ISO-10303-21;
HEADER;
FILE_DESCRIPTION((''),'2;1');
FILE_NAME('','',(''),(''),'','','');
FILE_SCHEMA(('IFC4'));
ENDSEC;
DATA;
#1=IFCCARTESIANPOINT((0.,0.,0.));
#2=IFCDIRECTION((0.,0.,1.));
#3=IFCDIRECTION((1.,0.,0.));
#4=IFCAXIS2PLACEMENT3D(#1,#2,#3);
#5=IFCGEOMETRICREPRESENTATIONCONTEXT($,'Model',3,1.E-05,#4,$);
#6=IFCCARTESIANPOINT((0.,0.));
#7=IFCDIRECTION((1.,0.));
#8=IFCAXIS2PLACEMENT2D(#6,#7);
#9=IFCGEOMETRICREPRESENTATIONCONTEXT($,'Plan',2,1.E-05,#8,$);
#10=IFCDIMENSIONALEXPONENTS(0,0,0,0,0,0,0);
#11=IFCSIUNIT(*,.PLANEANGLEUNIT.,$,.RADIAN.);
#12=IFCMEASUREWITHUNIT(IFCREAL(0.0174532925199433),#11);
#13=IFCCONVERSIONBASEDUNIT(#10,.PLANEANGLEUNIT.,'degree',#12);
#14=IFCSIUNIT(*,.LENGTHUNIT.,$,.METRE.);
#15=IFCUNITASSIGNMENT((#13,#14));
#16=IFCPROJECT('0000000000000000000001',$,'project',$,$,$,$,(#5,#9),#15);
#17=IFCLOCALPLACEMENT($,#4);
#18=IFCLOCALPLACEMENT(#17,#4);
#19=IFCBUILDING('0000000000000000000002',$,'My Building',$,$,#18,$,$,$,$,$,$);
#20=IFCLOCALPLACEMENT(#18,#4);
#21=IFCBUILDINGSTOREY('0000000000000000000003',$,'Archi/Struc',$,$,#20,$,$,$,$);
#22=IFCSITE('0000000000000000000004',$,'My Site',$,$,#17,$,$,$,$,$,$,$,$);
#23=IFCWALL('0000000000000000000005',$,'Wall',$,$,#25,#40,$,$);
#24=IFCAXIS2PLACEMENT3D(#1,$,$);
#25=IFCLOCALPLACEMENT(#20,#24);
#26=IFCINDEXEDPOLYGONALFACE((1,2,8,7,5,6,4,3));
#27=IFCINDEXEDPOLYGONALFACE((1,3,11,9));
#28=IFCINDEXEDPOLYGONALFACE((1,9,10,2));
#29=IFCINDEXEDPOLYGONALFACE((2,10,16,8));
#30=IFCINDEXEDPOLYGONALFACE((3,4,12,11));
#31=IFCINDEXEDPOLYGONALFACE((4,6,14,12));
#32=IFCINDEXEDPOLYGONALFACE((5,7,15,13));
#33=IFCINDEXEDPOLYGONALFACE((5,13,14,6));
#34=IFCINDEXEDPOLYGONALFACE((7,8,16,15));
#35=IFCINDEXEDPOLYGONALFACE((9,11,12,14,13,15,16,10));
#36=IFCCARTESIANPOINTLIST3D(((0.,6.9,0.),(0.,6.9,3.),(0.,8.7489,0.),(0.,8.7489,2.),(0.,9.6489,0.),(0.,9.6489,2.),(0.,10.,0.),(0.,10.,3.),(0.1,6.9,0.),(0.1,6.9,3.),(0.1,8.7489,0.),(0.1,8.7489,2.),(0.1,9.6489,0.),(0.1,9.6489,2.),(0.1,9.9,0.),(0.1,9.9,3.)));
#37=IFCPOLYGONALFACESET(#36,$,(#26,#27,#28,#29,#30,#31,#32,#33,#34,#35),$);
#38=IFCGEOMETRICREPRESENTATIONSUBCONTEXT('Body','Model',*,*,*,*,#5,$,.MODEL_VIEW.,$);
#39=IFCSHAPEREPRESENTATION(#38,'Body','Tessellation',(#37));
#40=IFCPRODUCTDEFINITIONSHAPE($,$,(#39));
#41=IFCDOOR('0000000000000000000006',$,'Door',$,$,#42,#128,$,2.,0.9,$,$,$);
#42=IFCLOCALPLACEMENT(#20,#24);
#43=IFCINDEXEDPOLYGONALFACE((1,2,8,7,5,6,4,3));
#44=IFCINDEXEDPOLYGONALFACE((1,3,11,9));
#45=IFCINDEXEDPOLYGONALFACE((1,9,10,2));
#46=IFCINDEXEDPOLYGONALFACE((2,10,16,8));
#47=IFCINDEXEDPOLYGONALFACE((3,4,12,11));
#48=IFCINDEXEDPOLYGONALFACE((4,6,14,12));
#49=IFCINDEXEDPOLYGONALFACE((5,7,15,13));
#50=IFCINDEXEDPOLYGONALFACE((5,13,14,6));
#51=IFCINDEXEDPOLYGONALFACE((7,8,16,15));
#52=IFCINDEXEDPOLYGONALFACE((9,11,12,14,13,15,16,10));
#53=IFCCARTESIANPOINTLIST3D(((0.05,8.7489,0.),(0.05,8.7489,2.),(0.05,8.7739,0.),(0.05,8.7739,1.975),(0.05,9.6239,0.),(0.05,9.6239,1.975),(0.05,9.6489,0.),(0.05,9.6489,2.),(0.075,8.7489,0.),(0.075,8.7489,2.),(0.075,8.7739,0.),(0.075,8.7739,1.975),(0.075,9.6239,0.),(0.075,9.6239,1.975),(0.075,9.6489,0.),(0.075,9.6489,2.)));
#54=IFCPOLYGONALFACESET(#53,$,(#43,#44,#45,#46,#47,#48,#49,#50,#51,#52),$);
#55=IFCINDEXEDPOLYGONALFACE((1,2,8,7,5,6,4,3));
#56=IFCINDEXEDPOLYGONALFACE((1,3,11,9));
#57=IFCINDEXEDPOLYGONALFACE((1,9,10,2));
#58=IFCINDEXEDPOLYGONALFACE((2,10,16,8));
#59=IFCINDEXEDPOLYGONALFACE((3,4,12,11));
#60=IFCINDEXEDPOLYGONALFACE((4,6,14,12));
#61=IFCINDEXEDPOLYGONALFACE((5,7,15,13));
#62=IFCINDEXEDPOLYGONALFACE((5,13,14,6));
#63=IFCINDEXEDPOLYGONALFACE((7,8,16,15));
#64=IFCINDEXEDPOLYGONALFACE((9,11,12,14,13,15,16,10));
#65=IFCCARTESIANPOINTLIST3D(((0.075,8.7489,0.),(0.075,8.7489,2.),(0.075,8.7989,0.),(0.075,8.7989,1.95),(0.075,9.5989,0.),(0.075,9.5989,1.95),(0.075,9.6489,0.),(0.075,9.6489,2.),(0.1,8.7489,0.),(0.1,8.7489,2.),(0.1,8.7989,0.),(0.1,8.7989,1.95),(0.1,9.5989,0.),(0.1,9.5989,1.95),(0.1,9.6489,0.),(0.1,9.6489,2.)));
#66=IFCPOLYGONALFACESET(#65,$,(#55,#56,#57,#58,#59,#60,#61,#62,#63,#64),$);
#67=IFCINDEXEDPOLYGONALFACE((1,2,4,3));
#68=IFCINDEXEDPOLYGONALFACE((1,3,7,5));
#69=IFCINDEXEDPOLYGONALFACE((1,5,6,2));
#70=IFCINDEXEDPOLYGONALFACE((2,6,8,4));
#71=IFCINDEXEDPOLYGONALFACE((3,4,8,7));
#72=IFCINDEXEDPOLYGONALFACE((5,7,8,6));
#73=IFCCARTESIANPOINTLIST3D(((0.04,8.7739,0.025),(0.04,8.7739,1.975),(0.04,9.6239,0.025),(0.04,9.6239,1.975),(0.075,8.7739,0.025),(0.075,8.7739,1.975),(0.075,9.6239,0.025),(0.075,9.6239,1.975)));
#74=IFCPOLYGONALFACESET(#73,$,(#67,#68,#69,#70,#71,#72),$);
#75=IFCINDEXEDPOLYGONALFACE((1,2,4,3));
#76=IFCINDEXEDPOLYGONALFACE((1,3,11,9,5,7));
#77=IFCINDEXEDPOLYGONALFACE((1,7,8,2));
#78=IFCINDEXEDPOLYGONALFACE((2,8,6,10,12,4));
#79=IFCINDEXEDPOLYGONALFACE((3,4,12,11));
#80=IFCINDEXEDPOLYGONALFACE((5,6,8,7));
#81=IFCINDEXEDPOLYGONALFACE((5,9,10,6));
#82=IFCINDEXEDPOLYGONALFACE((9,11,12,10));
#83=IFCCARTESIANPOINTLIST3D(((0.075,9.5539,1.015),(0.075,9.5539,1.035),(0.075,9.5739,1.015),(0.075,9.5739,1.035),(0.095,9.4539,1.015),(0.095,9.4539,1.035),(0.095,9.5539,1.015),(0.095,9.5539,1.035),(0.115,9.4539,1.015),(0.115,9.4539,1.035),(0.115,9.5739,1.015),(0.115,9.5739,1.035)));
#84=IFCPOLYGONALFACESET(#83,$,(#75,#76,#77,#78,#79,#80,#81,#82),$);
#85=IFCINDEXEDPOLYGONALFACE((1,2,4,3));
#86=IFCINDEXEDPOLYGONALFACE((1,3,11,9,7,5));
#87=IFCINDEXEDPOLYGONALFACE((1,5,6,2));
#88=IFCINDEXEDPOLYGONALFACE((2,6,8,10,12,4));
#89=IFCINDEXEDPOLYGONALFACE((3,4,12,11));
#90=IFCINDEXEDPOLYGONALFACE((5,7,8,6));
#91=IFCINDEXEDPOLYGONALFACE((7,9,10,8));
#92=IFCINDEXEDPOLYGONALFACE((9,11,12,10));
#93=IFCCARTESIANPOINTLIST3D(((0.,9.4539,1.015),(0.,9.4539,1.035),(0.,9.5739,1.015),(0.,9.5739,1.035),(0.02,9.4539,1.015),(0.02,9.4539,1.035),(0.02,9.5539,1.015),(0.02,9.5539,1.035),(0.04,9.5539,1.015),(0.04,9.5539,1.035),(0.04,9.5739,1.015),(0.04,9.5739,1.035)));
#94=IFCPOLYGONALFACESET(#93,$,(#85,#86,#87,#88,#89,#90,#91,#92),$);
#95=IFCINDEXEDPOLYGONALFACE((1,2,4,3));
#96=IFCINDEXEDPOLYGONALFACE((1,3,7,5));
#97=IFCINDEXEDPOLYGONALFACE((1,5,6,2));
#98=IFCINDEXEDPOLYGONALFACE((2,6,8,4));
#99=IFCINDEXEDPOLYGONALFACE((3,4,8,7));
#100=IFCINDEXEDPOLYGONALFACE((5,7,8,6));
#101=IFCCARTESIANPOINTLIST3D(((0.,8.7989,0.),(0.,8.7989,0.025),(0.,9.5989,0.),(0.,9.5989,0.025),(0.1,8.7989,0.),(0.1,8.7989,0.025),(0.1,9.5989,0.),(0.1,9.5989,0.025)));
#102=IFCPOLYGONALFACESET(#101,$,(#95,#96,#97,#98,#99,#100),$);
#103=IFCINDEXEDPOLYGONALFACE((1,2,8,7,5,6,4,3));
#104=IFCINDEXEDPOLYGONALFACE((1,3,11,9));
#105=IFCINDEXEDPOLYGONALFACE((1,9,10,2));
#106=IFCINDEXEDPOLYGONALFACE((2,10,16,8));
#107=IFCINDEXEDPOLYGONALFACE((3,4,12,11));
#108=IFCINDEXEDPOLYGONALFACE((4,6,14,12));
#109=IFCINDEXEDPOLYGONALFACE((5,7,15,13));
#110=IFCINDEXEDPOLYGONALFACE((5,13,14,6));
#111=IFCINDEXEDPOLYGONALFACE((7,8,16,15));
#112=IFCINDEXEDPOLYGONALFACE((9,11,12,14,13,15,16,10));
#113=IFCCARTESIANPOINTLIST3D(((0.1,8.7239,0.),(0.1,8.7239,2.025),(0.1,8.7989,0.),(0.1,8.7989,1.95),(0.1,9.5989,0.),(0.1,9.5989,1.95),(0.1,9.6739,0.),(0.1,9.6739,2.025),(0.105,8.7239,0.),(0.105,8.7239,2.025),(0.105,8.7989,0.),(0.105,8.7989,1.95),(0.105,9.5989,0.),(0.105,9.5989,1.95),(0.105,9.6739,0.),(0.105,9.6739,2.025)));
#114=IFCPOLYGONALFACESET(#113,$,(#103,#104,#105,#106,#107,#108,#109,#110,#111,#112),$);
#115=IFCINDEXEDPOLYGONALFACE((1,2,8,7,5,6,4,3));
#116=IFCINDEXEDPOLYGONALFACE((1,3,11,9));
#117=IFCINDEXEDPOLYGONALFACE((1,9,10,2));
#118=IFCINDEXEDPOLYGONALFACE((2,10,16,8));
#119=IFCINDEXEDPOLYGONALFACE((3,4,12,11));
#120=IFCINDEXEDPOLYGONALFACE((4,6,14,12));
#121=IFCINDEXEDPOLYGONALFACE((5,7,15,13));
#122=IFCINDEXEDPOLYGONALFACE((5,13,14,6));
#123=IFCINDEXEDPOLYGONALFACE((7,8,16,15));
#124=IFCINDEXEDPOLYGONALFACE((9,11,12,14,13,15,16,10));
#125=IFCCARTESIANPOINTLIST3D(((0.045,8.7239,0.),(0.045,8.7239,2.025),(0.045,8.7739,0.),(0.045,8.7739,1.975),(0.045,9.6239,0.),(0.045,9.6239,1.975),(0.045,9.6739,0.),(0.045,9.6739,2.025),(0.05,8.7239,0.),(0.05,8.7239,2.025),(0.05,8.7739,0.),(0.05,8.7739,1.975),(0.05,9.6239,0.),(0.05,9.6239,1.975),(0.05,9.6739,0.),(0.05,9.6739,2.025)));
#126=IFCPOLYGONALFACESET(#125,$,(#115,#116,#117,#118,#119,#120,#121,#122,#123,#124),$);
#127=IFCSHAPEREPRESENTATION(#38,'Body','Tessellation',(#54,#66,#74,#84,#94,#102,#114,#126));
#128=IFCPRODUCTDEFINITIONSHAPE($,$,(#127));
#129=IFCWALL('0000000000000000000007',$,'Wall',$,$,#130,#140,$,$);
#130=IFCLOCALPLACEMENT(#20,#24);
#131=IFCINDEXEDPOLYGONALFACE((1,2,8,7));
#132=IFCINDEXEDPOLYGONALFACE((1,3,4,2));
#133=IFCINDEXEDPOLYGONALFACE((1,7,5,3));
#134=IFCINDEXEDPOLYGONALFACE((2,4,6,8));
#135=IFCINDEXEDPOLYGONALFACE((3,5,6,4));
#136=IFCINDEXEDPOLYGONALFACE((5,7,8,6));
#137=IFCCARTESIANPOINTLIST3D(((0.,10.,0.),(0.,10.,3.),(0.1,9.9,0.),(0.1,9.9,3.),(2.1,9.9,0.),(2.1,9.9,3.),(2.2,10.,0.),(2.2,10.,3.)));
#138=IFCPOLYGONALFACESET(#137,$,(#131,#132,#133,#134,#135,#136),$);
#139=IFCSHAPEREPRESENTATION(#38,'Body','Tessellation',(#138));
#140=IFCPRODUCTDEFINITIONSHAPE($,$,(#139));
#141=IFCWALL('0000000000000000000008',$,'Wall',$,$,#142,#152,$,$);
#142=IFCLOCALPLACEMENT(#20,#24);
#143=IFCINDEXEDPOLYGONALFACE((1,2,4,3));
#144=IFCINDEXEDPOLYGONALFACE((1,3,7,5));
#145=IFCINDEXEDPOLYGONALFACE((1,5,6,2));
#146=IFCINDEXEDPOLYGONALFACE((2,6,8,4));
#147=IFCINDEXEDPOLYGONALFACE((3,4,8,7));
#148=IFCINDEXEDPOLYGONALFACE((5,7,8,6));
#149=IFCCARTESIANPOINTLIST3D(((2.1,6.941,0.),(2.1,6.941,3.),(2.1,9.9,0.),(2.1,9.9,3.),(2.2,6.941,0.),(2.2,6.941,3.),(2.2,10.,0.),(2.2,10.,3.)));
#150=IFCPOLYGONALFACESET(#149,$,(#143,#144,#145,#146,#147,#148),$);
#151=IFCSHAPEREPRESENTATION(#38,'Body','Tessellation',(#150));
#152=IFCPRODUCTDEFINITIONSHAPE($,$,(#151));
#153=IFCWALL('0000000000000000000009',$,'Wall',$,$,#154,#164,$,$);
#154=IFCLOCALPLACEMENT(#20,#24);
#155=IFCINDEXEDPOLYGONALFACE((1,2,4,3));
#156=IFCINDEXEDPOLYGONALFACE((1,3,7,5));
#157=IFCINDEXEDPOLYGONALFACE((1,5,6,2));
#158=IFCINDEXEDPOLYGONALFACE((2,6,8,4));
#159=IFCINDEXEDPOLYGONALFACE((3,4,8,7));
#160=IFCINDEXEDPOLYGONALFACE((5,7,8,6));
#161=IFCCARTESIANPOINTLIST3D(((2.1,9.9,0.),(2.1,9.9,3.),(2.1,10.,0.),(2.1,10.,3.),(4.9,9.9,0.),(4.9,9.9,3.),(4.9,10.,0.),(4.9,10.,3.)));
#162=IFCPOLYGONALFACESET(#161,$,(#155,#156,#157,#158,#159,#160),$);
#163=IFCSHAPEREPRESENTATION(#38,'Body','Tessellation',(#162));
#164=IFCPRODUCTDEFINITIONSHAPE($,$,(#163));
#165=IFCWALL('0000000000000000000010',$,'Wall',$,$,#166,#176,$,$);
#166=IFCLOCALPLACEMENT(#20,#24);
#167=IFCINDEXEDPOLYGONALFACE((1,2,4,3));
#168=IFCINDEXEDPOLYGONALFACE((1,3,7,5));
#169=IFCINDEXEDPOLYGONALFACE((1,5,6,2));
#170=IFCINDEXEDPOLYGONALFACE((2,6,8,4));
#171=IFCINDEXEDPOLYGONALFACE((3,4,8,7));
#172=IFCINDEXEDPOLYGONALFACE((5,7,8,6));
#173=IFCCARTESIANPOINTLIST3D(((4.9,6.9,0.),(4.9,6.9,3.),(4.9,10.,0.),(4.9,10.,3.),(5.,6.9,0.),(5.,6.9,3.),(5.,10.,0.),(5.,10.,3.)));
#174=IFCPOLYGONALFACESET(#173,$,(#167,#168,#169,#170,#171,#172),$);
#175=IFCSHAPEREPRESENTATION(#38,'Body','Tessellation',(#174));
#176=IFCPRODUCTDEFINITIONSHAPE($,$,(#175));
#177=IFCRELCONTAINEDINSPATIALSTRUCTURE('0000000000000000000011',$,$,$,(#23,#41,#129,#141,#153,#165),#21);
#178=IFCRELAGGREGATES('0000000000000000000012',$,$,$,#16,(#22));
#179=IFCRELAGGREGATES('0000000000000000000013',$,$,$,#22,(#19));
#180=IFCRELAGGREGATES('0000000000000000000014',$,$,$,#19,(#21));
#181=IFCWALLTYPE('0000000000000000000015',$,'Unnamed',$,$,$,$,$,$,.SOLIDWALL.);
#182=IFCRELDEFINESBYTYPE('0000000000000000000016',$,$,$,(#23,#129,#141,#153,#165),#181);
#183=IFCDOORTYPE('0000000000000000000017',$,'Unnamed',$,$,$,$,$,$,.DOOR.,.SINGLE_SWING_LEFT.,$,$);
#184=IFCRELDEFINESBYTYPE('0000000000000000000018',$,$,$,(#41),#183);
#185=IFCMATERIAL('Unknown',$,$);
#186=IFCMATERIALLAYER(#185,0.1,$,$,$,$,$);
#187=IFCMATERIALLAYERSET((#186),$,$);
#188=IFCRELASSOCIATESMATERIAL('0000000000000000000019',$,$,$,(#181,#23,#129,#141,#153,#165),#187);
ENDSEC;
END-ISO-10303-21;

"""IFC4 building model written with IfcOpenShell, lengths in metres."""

from ifc_helpers import new_model, entity, si_unit, converted_unit, frame, origin_with_axes, origin_2d_with_axis, place, context, subcontext, project, spatial, line, indexed_curve, outline, extrude, shape, source, transform, mapped, material, layer, layer_set, layer_usage, type_object, type_shapes, element, fill, save


model = new_model("IFC4")

# Units and contexts
model_context = context("Model", 3, precision=1e-05, world=origin_with_axes())
plan_context = context("Plan", 2, precision=1e-05, world=origin_2d_with_axis())
body_context_1 = subcontext(model_context, "Body", "Model", "MODEL_VIEW")
body_context_2 = subcontext(plan_context, "Body", "Plan", "PLAN_VIEW")
ifc_project = project(units=[converted_unit("PLANEANGLEUNIT", "degree", entity("IfcReal", 0.0174532925199433), si_unit("PLANEANGLEUNIT", "RADIAN"), dimensions=[0, 0, 0, 0, 0, 0, 0]), si_unit("LENGTHUNIT", "METRE")], contexts=[model_context, plan_context])

# Site, building, storey
site_placement = place(None, origin_with_axes())
site = spatial("IfcSite", under=ifc_project, at=site_placement, Name="My Site")
building_placement = place(site_placement, origin_with_axes())
building = spatial("IfcBuilding", under=site, at=building_placement, Name="My Building")
storey_placement = place(building_placement, origin_with_axes())
storey = spatial("IfcBuildingStorey", under=building, at=storey_placement, Name="Archi/Struc")

# Shared definitions
ifc_material = material(Name="Unknown")

# Shared definitions
ifc_layer_1 = layer(ifc_material, 0.1)
ifc_layer_set_1 = layer_set([ifc_layer_1])
wall_type = type_object("IfcWallType", Name="Unnamed", PredefinedType="SOLIDWALL", material=ifc_layer_set_1)

# Shared definitions
shared_shape_1 = source(origin_with_axes(), body_context_1, "Body", "SweptSolid", [
    extrude(outline(indexed_curve([(0.0, 0.0), (0.9, 0.0), (0.9, 2.0), (0.0, 2.0)], segments=[line(1, 2, 3, 4, 1)])), frame((0.0, -0.6, 0.0), z_axis=(0.0, -1.0, 0.0), x_axis=(1.0, 0.0, 0.0)), (0.0, 0.0, -1.0), 1.2),
])
door_type = type_object("IfcDoorType", Name="Unnamed", OperationType="SINGLE_SWING_LEFT", PredefinedType="DOOR")
shared_shape_2 = source(origin_with_axes(), body_context_1, "Body", "SweptSolid", [
    extrude(outline(indexed_curve([(0.0, 0.0), (0.0, 2.0), (0.9, 2.0), (0.9, 0.0), (0.875, 0.0), (0.875, 1.975), (0.025, 1.975), (0.025, 0.0)], segments=[line(1, 2, 3, 4, 5, 6, 7, 8, 1)])), frame((0.0, 0.025, 0.0), z_axis=(0.0, -1.0, 0.0), x_axis=(1.0, 0.0, 0.0)), (0.0, 0.0, -1.0), 0.025),
    extrude(outline(indexed_curve([(0.0, 0.0), (0.0, 2.0), (0.9, 2.0), (0.9, 0.0), (0.85, 0.0), (0.85, 1.95), (0.05, 1.95), (0.05, 0.0)], segments=[line(1, 2, 3, 4, 5, 6, 7, 8, 1)])), frame((0.0, 0.0, 0.0), z_axis=(0.0, -1.0, 0.0), x_axis=(1.0, 0.0, 0.0)), (0.0, 0.0, -1.0), 0.025),
    extrude(outline(indexed_curve([(0.0, 0.0), (0.85, 0.0), (0.85, 0.035), (0.0, 0.035)], segments=[line(1, 2, 3, 4, 1)])), frame((0.025, 0.025, 0.025), z_axis=(0.0, 0.0, 1.0), x_axis=(1.0, 0.0, 0.0)), (0.0, 0.0, 1.0), 1.95),
    extrude(outline(indexed_curve([(0.0, 0.0), (0.0, -0.04), (-0.12, -0.04), (-0.12, -0.02), (-0.02, -0.02), (-0.02, 0.0)], segments=[line(1, 2, 3, 4, 5, 6, 1)])), frame((0.825, 0.025, 1.015), z_axis=(0.0, 0.0, 1.0), x_axis=(1.0, 0.0, 0.0)), (0.0, 0.0, 1.0), 0.02),
    extrude(outline(indexed_curve([(0.0, 0.0), (0.0, 0.04), (-0.12, 0.04), (-0.12, 0.02), (-0.02, 0.02), (-0.02, 0.0)], segments=[line(1, 2, 3, 4, 5, 6, 1)])), frame((0.825, 0.06, 1.015), z_axis=(0.0, 0.0, 1.0), x_axis=(1.0, 0.0, 0.0)), (0.0, 0.0, 1.0), 0.02),
    extrude(outline(indexed_curve([(0.0, 0.0), (0.8, 0.0), (0.8, 0.1), (0.0, 0.1)], segments=[line(1, 2, 3, 4, 1)])), frame((0.05, 0.0, 0.0), z_axis=(0.0, 0.0, 1.0), x_axis=(1.0, 0.0, 0.0)), (0.0, 0.0, 1.0), 0.025),
    extrude(outline(indexed_curve([(0.0, 0.0), (0.0, 2.025), (0.95, 2.025), (0.95, 0.0), (0.875, 0.0), (0.875, 1.95), (0.075, 1.95), (0.075, 0.0)], segments=[line(1, 2, 3, 4, 5, 6, 7, 8, 1)])), frame((-0.025, -0.005, 0.0), z_axis=(0.0, -1.0, 0.0), x_axis=(1.0, 0.0, 0.0)), (0.0, 0.0, -1.0), 0.005),
    extrude(outline(indexed_curve([(0.0, 0.0), (0.0, 2.025), (0.95, 2.025), (0.95, 0.0), (0.9, 0.0), (0.9, 1.975), (0.05, 1.975), (0.05, 0.0)], segments=[line(1, 2, 3, 4, 5, 6, 7, 8, 1)])), frame((-0.025, 0.05, 0.0), z_axis=(0.0, -1.0, 0.0), x_axis=(1.0, 0.0, 0.0)), (0.0, 0.0, -1.0), 0.005),
])
shared_shape_3 = source(origin_with_axes(), body_context_2, "Body", "Curve2D", [
    entity("IfcIndexedPolyCurve", entity("IfcCartesianPointList2D", [[0.0, 0.0], [0.0, 0.05], [0.025, 0.05], [0.025, 0.025], [0.05, 0.025], [0.05, 0.0]]), [entity("IfcLineIndex", [1, 2, 3, 4, 5, 6, 1])]),
    entity("IfcIndexedPolyCurve", entity("IfcCartesianPointList2D", [[0.9, 0.0], [0.9, 0.05], [0.875, 0.05], [0.875, 0.025], [0.85, 0.025], [0.85, 0.0]]), [entity("IfcLineIndex", [1, 2, 3, 4, 5, 6, 1])]),
    entity("IfcTrimmedCurve", entity("IfcEllipse", entity("IfcAxis2Placement2D", entity("IfcCartesianPoint", [0.06, 0.05]), entity("IfcDirection", [1.0, 0.0])), 0.815, 0.85), [entity("IfcCartesianPoint", [0.875, 0.05])], [entity("IfcCartesianPoint", [0.06, 0.9])], True, "CARTESIAN"),
    entity("IfcIndexedPolyCurve", entity("IfcCartesianPointList2D", [[0.025, 0.05], [0.06, 0.05], [0.06, 0.9], [0.025, 0.9]]), [entity("IfcLineIndex", [1, 2, 3, 4, 1])]),
])
type_shapes(door_type, [shared_shape_2, shared_shape_3])

# Wall, opening, door
ifc_layer_usage_1 = layer_usage(ifc_layer_set_1, "AXIS2", "POSITIVE", 0.0)
wall_1_placement = place(storey_placement, frame((0.1, 6.9, 0.0), z_axis=(0.0, 0.0, 1.0), x_axis=(0.0, 1.0, 0.0)))
wall_1 = element("IfcWall", 1, at=wall_1_placement, inside=storey, type_object=wall_type, material=ifc_layer_usage_1, Name="Wall", context=body_context_1, shape_type="SweptSolid", body=[
    extrude(outline(indexed_curve([(0.0, 0.0), (0.0, 0.1), (3.1, 0.1), (3.0, 0.0)], segments=[line(1, 2, 3, 4, 1)])), origin_with_axes(), (0.0, 0.0, 1.0), 3.0),
])
opening_1_placement = place(wall_1_placement, frame((1.8489, 0.0, 0.0), z_axis=(0.0, 0.0, 1.0), x_axis=(1.0, 0.0, 0.0)))
opening_1 = element("IfcOpeningElement", 2, at=opening_1_placement, cuts=wall_1, PredefinedType="OPENING", context=body_context_1, shape_type="MappedRepresentation", body=[
    mapped(shared_shape_1, transform((0.0, 0.0, 0.0), x_axis=(1.0, 0.0, 0.0), y_axis=(0.0, 1.0, 0.0), z_axis=(0.0, 0.0, 1.0), scale=1.0)),
])
door_1_placement = place(opening_1_placement, frame((0.0, 0.0, 0.0), z_axis=(0.0, 0.0, 1.0), x_axis=(1.0, 0.0, 0.0)))
door_1 = element("IfcDoor", 3, at=door_1_placement, inside=storey, type_object=door_type, Name="Door", OverallHeight=2.0, OverallWidth=0.9, shapes=[
    shape(body_context_1, "Body", "MappedRepresentation", [mapped(shared_shape_2, transform((0.0, 0.0, 0.0), x_axis=(1.0, 0.0, 0.0), y_axis=(0.0, 1.0, 0.0), z_axis=(0.0, 0.0, 1.0), scale=1.0))]),
    shape(body_context_2, "Body", "MappedRepresentation", [mapped(shared_shape_3, transform((0.0, 0.0, 0.0), x_axis=(1.0, 0.0, 0.0), y_axis=(0.0, 1.0, 0.0), z_axis=(0.0, 0.0, 1.0), scale=1.0))]),
])
fill(opening_1, door_1)

# Walls
ifc_layer_usage_2 = layer_usage(ifc_layer_set_1, "AXIS2", "POSITIVE", 0.0)
wall_2_placement = place(storey_placement, frame((0.1, 9.9, 0.0), z_axis=(0.0, 0.0, 1.0), x_axis=(1.0, 0.0, 0.0)))
element("IfcWall", 4, at=wall_2_placement, inside=storey, type_object=wall_type, material=ifc_layer_usage_2, Name="Wall", context=body_context_1, shape_type="SweptSolid", body=[
    extrude(outline(indexed_curve([(0.0, 0.0), (-0.1, 0.1), (2.1, 0.1), (2.0, 0.0)], segments=[line(1, 2, 3, 4, 1)])), origin_with_axes(), (0.0, 0.0, 1.0), 3.0),
])
ifc_layer_usage_3 = layer_usage(ifc_layer_set_1, "AXIS2", "POSITIVE", 0.0)
wall_3_placement = place(storey_placement, frame((2.1, 9.9, 0.0), z_axis=(0.0, 0.0, 1.0), x_axis=(0.0, -1.0, 0.0)))
element("IfcWall", 5, at=wall_3_placement, inside=storey, type_object=wall_type, material=ifc_layer_usage_3, Name="Wall", context=body_context_1, shape_type="SweptSolid", body=[
    extrude(outline(indexed_curve([(0.0, 0.0), (-0.1, 0.1), (2.959, 0.1), (2.959, 0.0)], segments=[line(1, 2, 3, 4, 1)])), origin_with_axes(), (0.0, 0.0, 1.0), 3.0),
])
ifc_layer_usage_4 = layer_usage(ifc_layer_set_1, "AXIS2", "POSITIVE", 0.0)
wall_4_placement = place(storey_placement, frame((2.1, 9.9, 0.0), z_axis=(0.0, 0.0, 1.0), x_axis=(1.0, 0.0, 0.0)))
element("IfcWall", 6, at=wall_4_placement, inside=storey, type_object=wall_type, material=ifc_layer_usage_4, Name="Wall", context=body_context_1, shape_type="SweptSolid", body=[
    extrude(outline(indexed_curve([(0.0, 0.0), (0.0, 0.1), (2.8, 0.1), (2.8, 0.0)], segments=[line(1, 2, 3, 4, 1)])), origin_with_axes(), (0.0, 0.0, 1.0), 3.0),
])
ifc_layer_usage_5 = layer_usage(ifc_layer_set_1, "AXIS2", "POSITIVE", 0.0)
wall_5_placement = place(storey_placement, frame((4.9, 10.0, 0.0), z_axis=(0.0, 0.0, 1.0), x_axis=(0.0, -1.0, 0.0)))
element("IfcWall", 7, at=wall_5_placement, inside=storey, type_object=wall_type, material=ifc_layer_usage_5, Name="Wall", context=body_context_1, shape_type="SweptSolid", body=[
    extrude(outline(indexed_curve([(0.0, 0.0), (0.0, 0.1), (3.1, 0.1), (3.1, 0.0)], segments=[line(1, 2, 3, 4, 1)])), origin_with_axes(), (0.0, 0.0, 1.0), 3.0),
])

save(model, "model.ifc")
